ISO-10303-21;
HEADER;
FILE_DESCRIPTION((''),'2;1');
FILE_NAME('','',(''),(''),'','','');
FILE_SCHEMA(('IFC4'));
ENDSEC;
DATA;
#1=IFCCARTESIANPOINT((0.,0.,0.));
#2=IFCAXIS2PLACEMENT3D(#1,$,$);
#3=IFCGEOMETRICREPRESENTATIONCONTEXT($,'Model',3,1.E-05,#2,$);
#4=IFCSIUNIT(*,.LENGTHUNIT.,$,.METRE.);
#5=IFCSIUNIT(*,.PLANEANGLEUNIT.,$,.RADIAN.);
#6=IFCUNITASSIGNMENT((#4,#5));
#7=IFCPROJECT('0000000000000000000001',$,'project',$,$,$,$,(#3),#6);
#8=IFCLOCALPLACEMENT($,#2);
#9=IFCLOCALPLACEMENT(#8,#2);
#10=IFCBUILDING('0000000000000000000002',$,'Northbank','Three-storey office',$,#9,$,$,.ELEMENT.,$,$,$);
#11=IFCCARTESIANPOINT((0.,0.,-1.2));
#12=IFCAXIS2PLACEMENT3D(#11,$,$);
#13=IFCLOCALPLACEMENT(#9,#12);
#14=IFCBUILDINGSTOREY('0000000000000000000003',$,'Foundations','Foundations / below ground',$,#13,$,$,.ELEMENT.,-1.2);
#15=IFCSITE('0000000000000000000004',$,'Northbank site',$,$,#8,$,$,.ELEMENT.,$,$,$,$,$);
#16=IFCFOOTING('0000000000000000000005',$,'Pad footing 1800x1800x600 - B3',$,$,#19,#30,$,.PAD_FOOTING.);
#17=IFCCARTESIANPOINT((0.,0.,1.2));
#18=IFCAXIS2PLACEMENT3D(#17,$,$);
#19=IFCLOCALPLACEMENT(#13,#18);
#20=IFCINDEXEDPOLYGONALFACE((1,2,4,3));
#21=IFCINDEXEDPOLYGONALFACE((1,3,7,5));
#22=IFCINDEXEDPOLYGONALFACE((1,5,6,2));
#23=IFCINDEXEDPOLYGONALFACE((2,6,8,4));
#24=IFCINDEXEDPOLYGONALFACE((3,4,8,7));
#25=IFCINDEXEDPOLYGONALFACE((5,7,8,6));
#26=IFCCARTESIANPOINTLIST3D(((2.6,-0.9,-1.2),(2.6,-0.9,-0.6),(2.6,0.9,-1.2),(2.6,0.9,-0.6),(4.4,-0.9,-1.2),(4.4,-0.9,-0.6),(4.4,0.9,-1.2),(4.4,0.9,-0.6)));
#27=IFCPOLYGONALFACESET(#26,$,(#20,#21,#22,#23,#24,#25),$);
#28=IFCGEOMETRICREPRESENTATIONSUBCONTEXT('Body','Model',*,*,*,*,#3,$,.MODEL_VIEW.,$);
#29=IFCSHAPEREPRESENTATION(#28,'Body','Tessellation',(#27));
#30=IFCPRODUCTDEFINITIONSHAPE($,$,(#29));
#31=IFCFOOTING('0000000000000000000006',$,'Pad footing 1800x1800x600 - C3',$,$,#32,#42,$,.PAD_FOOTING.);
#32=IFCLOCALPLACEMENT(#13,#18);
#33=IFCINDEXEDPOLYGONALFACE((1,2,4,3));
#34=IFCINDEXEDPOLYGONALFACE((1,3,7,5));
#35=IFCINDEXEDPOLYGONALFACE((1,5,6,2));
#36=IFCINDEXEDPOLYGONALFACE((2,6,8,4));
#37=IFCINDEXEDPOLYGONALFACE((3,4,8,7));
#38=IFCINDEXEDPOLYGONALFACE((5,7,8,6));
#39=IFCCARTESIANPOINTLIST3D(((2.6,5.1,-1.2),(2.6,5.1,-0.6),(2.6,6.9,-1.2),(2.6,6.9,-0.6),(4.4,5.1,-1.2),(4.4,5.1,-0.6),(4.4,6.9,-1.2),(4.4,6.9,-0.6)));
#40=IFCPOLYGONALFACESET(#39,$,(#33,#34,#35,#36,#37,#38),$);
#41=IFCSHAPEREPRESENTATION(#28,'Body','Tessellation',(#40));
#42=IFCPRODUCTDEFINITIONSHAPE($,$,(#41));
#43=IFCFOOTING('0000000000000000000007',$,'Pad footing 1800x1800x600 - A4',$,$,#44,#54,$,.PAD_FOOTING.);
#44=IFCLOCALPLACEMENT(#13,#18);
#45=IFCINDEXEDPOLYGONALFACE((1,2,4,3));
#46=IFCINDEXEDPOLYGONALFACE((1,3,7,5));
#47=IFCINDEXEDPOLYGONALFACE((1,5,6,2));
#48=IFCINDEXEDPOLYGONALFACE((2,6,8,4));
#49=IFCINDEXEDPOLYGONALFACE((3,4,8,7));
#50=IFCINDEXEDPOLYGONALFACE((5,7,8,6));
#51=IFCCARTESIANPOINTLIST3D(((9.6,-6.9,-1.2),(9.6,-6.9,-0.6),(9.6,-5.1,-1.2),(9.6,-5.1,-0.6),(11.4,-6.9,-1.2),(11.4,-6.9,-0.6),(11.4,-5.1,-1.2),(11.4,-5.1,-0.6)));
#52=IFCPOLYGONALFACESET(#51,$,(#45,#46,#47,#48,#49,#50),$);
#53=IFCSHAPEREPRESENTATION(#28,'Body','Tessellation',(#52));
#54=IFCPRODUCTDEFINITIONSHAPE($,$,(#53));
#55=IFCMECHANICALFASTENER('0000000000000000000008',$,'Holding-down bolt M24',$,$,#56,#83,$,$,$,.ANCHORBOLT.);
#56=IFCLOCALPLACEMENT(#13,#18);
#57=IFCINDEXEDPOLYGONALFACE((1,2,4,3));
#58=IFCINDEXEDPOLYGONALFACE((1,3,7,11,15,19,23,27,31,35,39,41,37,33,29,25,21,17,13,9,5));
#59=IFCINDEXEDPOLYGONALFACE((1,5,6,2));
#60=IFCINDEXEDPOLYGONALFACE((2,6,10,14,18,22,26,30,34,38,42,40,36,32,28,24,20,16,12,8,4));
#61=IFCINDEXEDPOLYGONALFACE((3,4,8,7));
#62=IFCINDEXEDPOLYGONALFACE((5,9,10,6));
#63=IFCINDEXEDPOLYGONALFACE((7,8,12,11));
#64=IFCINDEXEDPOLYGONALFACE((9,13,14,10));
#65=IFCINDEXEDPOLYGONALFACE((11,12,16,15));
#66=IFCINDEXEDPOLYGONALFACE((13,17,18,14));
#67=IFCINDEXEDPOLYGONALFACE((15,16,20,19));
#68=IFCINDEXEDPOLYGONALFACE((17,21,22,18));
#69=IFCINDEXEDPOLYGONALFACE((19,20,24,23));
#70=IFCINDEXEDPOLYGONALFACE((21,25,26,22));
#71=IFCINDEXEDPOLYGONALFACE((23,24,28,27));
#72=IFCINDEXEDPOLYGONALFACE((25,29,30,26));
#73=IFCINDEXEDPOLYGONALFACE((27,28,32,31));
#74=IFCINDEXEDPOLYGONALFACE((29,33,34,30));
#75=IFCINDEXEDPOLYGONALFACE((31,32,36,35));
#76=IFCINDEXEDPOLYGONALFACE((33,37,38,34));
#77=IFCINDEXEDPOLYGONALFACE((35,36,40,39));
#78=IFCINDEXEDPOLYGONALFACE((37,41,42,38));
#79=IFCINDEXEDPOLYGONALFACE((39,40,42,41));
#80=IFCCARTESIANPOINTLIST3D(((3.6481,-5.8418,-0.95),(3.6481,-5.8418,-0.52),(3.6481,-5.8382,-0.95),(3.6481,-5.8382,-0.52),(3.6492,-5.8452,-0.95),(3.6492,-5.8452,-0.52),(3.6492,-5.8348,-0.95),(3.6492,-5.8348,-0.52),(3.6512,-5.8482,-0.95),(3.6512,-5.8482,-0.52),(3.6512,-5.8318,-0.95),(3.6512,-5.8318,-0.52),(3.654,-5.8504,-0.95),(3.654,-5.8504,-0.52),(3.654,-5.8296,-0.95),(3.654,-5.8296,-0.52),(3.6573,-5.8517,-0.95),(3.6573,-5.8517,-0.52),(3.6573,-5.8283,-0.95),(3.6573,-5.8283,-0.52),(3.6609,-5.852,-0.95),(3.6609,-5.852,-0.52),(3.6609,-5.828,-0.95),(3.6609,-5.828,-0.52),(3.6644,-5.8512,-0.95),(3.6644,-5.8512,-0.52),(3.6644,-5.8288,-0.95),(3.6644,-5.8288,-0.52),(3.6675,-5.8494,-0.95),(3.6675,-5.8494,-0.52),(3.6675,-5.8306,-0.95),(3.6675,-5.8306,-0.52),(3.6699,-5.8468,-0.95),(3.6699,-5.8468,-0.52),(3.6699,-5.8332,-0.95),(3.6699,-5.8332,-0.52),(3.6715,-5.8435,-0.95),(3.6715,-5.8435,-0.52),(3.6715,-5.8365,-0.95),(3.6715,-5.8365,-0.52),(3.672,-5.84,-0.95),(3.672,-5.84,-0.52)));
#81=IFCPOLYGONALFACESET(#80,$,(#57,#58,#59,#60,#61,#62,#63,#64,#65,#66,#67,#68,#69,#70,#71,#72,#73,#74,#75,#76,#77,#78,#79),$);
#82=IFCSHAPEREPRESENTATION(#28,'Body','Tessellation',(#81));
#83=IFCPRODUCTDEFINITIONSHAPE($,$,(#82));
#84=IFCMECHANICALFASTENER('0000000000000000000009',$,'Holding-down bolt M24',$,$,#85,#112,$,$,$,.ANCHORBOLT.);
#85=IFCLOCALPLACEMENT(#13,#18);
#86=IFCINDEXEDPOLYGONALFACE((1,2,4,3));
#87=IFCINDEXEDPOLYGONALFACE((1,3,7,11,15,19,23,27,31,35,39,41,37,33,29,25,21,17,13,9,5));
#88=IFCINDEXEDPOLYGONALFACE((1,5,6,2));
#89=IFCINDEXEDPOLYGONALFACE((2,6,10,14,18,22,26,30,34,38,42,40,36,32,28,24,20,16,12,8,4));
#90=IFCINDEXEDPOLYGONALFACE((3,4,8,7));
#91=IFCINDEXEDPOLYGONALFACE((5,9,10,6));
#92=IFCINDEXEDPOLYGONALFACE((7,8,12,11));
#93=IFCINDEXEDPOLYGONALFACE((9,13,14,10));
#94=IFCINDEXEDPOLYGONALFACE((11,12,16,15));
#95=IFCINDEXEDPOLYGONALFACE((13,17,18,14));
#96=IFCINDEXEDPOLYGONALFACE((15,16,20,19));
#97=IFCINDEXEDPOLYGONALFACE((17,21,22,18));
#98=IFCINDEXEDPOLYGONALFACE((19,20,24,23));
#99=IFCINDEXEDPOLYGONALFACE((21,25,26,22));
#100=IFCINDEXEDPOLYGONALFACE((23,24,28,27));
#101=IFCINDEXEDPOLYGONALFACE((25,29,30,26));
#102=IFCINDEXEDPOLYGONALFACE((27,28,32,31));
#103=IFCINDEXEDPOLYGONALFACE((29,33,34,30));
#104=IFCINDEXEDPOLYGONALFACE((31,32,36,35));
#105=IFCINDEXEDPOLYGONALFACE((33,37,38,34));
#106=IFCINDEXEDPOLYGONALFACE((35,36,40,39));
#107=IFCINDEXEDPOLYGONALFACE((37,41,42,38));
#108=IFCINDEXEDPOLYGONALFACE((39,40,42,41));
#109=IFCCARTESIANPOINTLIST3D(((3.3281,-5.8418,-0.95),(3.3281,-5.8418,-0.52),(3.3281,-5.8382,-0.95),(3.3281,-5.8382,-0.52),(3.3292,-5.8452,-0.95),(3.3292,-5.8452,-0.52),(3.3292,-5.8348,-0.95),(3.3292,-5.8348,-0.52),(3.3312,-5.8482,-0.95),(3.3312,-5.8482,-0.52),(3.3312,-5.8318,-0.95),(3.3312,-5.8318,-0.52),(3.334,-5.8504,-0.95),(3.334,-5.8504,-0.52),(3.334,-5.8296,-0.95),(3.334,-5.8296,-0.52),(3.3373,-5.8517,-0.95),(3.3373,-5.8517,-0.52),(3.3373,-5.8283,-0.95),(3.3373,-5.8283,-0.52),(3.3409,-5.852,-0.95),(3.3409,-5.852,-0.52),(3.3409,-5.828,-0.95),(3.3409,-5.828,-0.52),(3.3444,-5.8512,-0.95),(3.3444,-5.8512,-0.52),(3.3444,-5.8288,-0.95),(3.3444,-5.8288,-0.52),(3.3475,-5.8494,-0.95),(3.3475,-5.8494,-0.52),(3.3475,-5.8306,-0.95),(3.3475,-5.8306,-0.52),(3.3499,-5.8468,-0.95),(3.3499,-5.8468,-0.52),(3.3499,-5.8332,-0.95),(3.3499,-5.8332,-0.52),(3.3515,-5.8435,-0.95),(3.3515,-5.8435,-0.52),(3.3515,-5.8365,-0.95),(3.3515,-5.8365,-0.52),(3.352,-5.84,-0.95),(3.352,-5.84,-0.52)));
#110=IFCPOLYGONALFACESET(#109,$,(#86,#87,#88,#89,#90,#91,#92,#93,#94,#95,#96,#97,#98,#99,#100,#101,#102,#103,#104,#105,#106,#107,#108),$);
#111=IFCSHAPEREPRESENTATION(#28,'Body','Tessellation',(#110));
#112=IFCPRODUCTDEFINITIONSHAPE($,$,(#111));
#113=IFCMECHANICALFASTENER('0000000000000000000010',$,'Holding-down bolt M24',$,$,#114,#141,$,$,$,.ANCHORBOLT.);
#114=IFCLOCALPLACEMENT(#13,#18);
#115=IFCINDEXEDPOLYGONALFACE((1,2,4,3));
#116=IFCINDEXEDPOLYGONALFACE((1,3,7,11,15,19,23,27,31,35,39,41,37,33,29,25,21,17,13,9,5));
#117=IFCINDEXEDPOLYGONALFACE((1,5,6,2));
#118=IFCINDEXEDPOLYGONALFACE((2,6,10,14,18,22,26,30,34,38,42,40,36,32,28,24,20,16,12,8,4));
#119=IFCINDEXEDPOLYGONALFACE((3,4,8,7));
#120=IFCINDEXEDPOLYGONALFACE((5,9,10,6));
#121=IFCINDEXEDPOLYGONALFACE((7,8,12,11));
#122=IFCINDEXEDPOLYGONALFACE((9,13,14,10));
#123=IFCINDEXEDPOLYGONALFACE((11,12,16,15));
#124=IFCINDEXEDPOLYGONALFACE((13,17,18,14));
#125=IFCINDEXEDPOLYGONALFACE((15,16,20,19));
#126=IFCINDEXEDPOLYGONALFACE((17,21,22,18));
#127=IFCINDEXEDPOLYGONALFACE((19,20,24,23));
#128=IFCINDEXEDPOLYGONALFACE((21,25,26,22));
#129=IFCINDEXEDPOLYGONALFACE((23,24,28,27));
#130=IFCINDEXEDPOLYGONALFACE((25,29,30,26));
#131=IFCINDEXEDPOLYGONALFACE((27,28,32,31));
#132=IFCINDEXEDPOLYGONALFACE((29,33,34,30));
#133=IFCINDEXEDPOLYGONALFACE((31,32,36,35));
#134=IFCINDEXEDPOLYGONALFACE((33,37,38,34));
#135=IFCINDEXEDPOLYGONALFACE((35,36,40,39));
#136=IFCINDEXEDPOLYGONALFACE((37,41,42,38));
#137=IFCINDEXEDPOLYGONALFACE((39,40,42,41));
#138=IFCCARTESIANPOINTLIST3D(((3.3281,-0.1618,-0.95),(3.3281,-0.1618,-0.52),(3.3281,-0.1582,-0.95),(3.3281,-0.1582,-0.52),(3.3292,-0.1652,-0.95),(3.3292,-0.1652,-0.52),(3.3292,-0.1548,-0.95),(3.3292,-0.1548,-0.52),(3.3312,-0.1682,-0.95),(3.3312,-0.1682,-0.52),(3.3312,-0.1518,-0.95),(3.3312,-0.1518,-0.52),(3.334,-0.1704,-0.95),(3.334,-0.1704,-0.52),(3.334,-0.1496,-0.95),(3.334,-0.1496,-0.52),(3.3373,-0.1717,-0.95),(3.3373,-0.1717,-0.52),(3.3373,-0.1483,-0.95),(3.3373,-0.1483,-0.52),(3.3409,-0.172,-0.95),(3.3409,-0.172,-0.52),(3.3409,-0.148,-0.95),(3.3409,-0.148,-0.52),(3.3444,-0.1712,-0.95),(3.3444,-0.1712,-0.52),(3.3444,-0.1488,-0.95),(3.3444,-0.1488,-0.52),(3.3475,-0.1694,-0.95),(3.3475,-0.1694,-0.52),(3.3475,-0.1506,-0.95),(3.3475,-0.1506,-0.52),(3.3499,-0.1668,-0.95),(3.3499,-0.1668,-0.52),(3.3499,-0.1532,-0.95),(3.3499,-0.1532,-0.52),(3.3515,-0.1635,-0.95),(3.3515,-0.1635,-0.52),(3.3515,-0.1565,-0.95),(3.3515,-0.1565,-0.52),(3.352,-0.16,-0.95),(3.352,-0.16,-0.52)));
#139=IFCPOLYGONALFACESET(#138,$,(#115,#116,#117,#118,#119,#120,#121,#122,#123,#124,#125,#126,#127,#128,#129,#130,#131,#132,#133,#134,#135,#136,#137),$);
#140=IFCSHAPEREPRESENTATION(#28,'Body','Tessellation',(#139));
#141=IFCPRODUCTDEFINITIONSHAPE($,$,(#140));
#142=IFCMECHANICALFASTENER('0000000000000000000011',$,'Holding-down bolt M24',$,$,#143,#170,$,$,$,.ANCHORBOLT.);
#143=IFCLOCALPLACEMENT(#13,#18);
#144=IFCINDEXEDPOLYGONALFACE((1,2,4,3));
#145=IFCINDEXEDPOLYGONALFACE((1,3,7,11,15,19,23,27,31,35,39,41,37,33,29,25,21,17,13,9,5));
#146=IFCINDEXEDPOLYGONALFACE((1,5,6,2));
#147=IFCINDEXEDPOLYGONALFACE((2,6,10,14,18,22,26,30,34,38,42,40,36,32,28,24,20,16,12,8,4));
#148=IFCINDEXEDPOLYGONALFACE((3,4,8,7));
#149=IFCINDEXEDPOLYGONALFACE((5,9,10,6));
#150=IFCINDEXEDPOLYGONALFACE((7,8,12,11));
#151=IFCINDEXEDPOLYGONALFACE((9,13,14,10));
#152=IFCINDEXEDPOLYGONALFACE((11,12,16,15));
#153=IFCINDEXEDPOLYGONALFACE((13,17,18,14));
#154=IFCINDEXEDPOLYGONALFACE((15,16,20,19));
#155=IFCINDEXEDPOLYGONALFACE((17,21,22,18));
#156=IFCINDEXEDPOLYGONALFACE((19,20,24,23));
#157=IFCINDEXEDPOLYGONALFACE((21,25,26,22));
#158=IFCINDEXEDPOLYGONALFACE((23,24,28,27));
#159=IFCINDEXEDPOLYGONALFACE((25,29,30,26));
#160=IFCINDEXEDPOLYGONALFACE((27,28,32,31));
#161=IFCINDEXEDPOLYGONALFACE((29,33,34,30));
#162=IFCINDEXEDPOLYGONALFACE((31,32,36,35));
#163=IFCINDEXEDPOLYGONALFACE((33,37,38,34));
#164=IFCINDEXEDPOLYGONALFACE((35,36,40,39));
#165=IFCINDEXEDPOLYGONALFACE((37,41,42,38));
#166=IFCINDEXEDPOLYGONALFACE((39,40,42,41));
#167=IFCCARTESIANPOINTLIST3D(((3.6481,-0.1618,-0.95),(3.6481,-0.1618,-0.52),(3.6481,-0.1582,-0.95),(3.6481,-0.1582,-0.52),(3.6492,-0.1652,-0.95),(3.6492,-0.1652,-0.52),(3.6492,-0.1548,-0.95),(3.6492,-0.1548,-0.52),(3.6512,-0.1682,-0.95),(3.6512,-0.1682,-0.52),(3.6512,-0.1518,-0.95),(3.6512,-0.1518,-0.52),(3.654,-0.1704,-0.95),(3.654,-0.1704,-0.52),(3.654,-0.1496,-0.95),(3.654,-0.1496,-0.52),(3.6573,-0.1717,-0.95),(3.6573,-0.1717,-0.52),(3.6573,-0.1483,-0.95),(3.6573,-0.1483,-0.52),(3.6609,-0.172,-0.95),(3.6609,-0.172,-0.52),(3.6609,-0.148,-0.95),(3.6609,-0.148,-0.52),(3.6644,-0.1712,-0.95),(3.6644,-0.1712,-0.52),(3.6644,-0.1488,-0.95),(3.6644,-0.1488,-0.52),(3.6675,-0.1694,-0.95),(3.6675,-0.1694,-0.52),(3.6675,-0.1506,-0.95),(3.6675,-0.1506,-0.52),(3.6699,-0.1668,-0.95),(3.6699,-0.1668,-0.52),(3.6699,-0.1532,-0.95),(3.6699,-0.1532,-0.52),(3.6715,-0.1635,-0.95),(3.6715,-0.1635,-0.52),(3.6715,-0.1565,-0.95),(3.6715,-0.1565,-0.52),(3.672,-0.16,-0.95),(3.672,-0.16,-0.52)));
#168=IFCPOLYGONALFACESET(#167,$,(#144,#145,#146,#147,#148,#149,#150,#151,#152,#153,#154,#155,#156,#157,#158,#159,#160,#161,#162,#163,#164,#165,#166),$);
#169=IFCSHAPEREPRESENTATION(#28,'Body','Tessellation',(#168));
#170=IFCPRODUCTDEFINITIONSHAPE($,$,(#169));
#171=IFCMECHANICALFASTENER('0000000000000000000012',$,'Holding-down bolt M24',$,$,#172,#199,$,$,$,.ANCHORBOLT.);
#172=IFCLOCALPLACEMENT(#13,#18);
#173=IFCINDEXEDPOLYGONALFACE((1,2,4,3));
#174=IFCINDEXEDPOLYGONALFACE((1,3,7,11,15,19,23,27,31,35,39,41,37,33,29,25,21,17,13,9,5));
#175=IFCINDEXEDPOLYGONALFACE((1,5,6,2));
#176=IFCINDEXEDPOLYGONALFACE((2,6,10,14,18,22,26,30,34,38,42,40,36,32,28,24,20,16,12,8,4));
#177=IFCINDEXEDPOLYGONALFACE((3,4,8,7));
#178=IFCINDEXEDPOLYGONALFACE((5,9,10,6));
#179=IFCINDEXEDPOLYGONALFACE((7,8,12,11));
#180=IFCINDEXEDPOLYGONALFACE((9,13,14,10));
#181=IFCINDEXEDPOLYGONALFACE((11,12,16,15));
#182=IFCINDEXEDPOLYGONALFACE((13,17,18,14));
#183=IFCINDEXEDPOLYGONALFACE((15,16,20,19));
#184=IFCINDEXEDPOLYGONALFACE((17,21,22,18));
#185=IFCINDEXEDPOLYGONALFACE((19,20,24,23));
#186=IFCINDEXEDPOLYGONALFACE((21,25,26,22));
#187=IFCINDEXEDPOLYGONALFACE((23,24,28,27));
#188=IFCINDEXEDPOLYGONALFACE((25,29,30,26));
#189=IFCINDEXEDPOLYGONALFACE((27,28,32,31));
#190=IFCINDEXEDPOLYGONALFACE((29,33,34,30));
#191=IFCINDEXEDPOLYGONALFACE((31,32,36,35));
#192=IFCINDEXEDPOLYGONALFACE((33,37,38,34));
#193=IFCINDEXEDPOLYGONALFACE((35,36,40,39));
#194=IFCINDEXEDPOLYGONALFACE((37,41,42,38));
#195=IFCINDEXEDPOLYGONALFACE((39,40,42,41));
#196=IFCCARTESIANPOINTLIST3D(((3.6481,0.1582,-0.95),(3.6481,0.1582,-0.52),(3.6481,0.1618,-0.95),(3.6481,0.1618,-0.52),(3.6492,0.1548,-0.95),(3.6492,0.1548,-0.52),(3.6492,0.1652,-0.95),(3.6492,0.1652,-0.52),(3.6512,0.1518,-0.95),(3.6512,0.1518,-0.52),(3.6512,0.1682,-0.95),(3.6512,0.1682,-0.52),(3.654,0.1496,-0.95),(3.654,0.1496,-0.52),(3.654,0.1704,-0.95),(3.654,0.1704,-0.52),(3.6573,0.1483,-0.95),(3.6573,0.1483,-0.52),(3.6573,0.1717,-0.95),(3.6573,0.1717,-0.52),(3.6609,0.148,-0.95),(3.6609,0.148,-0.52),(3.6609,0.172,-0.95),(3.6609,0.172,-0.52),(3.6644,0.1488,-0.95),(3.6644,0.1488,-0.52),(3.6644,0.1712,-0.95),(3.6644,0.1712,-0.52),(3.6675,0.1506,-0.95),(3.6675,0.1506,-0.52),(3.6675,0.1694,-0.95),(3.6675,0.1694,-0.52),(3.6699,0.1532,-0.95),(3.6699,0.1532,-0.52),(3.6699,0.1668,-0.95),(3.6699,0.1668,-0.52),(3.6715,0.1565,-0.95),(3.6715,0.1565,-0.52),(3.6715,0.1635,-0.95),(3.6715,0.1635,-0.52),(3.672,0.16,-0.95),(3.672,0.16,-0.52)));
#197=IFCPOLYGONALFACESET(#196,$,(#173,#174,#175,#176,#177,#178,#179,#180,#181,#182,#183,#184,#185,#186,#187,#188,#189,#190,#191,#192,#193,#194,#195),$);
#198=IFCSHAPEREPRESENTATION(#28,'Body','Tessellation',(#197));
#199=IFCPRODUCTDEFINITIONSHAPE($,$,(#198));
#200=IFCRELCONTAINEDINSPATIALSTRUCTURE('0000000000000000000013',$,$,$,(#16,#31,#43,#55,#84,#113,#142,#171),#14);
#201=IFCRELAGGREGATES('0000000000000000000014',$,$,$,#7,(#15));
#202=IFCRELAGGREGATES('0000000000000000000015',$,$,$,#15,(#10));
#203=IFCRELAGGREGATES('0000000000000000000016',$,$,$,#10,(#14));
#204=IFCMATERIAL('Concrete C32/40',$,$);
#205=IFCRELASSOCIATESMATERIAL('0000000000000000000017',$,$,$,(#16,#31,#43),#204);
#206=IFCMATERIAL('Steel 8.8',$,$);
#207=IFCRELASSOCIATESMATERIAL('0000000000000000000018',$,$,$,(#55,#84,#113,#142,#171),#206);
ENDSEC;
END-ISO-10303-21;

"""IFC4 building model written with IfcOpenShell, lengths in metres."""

from ifc_helpers import new_model, si_unit, frame, origin, place, context, subcontext, project, spatial, rectangle, circle, extrude, material, element, save


model = new_model("IFC4")

# Units and contexts
model_context = context("Model", 3, precision=1e-05, world=origin())
body_context = subcontext(model_context, "Body", "Model", "MODEL_VIEW")
ifc_project = project(units=[si_unit("LENGTHUNIT", "METRE"), si_unit("PLANEANGLEUNIT", "RADIAN")], contexts=[model_context])

# Site, building, storey
site_placement = place(None, origin())
site = spatial("IfcSite", under=ifc_project, at=site_placement, Name="Northbank site", CompositionType="ELEMENT")
building_placement = place(site_placement, origin())
building = spatial("IfcBuilding", under=site, at=building_placement, Name="Northbank", Description="Three-storey office", CompositionType="ELEMENT")
storey_placement = place(building_placement, frame((0.0, 0.0, -1.2)))
storey = spatial("IfcBuildingStorey", under=building, at=storey_placement, Name="Foundations", Description="Foundations / below ground", CompositionType="ELEMENT", Elevation=-1.2)

# Footings
ifc_material_1 = material(Name="Concrete C32/40")
footing_1_placement = place(storey_placement, frame((0.0, 0.0, 1.2)))
element("IfcFooting", 1, at=footing_1_placement, inside=storey, material=ifc_material_1, Name="Pad footing 1800x1800x600 - B3", PredefinedType="PAD_FOOTING", context=body_context, shape_type="SweptSolid", body=[
    extrude(rectangle(XDim=1.8, YDim=1.8), frame((3.5, 0.0, -1.2)), (0.0, 0.0, 1.0), 0.6),
])
footing_2_placement = place(storey_placement, frame((0.0, 0.0, 1.2)))
element("IfcFooting", 2, at=footing_2_placement, inside=storey, material=ifc_material_1, Name="Pad footing 1800x1800x600 - C3", PredefinedType="PAD_FOOTING", context=body_context, shape_type="SweptSolid", body=[
    extrude(rectangle(XDim=1.8, YDim=1.8), frame((3.5, 6.0, -1.2)), (0.0, 0.0, 1.0), 0.6),
])
footing_3_placement = place(storey_placement, frame((0.0, 0.0, 1.2)))
element("IfcFooting", 3, at=footing_3_placement, inside=storey, material=ifc_material_1, Name="Pad footing 1800x1800x600 - A4", PredefinedType="PAD_FOOTING", context=body_context, shape_type="SweptSolid", body=[
    extrude(rectangle(XDim=1.8, YDim=1.8), frame((10.5, -6.0, -1.2)), (0.0, 0.0, 1.0), 0.6),
])

# Mechanical fasteners
ifc_material_2 = material(Name="Steel 8.8")
mechanical_fastener_1_placement = place(storey_placement, frame((0.0, 0.0, 1.2)))
element("IfcMechanicalFastener", 4, at=mechanical_fastener_1_placement, inside=storey, material=ifc_material_2, Name="Holding-down bolt M24", PredefinedType="ANCHORBOLT", context=body_context, shape_type="SweptSolid", body=[
    extrude(circle(Radius=0.012), frame((3.66, -5.84, -0.95), z_axis=(0.0, 0.0, 1.0), x_axis=(1.0, 0.0, 0.0)), (0.0, 0.0, 1.0), 0.43),
])
mechanical_fastener_2_placement = place(storey_placement, frame((0.0, 0.0, 1.2)))
element("IfcMechanicalFastener", 5, at=mechanical_fastener_2_placement, inside=storey, material=ifc_material_2, Name="Holding-down bolt M24", PredefinedType="ANCHORBOLT", context=body_context, shape_type="SweptSolid", body=[
    extrude(circle(Radius=0.012), frame((3.34, -5.84, -0.95), z_axis=(0.0, 0.0, 1.0), x_axis=(1.0, 0.0, 0.0)), (0.0, 0.0, 1.0), 0.43),
])
mechanical_fastener_3_placement = place(storey_placement, frame((0.0, 0.0, 1.2)))
element("IfcMechanicalFastener", 6, at=mechanical_fastener_3_placement, inside=storey, material=ifc_material_2, Name="Holding-down bolt M24", PredefinedType="ANCHORBOLT", context=body_context, shape_type="SweptSolid", body=[
    extrude(circle(Radius=0.012), frame((3.34, -0.16, -0.95), z_axis=(0.0, 0.0, 1.0), x_axis=(1.0, 0.0, 0.0)), (0.0, 0.0, 1.0), 0.43),
])
mechanical_fastener_4_placement = place(storey_placement, frame((0.0, 0.0, 1.2)))
element("IfcMechanicalFastener", 7, at=mechanical_fastener_4_placement, inside=storey, material=ifc_material_2, Name="Holding-down bolt M24", PredefinedType="ANCHORBOLT", context=body_context, shape_type="SweptSolid", body=[
    extrude(circle(Radius=0.012), frame((3.66, -0.16, -0.95), z_axis=(0.0, 0.0, 1.0), x_axis=(1.0, 0.0, 0.0)), (0.0, 0.0, 1.0), 0.43),
])
mechanical_fastener_5_placement = place(storey_placement, frame((0.0, 0.0, 1.2)))
element("IfcMechanicalFastener", 8, at=mechanical_fastener_5_placement, inside=storey, material=ifc_material_2, Name="Holding-down bolt M24", PredefinedType="ANCHORBOLT", context=body_context, shape_type="SweptSolid", body=[
    extrude(circle(Radius=0.012), frame((3.66, 0.16, -0.95), z_axis=(0.0, 0.0, 1.0), x_axis=(1.0, 0.0, 0.0)), (0.0, 0.0, 1.0), 0.43),
])

save(model, "model.ifc")
